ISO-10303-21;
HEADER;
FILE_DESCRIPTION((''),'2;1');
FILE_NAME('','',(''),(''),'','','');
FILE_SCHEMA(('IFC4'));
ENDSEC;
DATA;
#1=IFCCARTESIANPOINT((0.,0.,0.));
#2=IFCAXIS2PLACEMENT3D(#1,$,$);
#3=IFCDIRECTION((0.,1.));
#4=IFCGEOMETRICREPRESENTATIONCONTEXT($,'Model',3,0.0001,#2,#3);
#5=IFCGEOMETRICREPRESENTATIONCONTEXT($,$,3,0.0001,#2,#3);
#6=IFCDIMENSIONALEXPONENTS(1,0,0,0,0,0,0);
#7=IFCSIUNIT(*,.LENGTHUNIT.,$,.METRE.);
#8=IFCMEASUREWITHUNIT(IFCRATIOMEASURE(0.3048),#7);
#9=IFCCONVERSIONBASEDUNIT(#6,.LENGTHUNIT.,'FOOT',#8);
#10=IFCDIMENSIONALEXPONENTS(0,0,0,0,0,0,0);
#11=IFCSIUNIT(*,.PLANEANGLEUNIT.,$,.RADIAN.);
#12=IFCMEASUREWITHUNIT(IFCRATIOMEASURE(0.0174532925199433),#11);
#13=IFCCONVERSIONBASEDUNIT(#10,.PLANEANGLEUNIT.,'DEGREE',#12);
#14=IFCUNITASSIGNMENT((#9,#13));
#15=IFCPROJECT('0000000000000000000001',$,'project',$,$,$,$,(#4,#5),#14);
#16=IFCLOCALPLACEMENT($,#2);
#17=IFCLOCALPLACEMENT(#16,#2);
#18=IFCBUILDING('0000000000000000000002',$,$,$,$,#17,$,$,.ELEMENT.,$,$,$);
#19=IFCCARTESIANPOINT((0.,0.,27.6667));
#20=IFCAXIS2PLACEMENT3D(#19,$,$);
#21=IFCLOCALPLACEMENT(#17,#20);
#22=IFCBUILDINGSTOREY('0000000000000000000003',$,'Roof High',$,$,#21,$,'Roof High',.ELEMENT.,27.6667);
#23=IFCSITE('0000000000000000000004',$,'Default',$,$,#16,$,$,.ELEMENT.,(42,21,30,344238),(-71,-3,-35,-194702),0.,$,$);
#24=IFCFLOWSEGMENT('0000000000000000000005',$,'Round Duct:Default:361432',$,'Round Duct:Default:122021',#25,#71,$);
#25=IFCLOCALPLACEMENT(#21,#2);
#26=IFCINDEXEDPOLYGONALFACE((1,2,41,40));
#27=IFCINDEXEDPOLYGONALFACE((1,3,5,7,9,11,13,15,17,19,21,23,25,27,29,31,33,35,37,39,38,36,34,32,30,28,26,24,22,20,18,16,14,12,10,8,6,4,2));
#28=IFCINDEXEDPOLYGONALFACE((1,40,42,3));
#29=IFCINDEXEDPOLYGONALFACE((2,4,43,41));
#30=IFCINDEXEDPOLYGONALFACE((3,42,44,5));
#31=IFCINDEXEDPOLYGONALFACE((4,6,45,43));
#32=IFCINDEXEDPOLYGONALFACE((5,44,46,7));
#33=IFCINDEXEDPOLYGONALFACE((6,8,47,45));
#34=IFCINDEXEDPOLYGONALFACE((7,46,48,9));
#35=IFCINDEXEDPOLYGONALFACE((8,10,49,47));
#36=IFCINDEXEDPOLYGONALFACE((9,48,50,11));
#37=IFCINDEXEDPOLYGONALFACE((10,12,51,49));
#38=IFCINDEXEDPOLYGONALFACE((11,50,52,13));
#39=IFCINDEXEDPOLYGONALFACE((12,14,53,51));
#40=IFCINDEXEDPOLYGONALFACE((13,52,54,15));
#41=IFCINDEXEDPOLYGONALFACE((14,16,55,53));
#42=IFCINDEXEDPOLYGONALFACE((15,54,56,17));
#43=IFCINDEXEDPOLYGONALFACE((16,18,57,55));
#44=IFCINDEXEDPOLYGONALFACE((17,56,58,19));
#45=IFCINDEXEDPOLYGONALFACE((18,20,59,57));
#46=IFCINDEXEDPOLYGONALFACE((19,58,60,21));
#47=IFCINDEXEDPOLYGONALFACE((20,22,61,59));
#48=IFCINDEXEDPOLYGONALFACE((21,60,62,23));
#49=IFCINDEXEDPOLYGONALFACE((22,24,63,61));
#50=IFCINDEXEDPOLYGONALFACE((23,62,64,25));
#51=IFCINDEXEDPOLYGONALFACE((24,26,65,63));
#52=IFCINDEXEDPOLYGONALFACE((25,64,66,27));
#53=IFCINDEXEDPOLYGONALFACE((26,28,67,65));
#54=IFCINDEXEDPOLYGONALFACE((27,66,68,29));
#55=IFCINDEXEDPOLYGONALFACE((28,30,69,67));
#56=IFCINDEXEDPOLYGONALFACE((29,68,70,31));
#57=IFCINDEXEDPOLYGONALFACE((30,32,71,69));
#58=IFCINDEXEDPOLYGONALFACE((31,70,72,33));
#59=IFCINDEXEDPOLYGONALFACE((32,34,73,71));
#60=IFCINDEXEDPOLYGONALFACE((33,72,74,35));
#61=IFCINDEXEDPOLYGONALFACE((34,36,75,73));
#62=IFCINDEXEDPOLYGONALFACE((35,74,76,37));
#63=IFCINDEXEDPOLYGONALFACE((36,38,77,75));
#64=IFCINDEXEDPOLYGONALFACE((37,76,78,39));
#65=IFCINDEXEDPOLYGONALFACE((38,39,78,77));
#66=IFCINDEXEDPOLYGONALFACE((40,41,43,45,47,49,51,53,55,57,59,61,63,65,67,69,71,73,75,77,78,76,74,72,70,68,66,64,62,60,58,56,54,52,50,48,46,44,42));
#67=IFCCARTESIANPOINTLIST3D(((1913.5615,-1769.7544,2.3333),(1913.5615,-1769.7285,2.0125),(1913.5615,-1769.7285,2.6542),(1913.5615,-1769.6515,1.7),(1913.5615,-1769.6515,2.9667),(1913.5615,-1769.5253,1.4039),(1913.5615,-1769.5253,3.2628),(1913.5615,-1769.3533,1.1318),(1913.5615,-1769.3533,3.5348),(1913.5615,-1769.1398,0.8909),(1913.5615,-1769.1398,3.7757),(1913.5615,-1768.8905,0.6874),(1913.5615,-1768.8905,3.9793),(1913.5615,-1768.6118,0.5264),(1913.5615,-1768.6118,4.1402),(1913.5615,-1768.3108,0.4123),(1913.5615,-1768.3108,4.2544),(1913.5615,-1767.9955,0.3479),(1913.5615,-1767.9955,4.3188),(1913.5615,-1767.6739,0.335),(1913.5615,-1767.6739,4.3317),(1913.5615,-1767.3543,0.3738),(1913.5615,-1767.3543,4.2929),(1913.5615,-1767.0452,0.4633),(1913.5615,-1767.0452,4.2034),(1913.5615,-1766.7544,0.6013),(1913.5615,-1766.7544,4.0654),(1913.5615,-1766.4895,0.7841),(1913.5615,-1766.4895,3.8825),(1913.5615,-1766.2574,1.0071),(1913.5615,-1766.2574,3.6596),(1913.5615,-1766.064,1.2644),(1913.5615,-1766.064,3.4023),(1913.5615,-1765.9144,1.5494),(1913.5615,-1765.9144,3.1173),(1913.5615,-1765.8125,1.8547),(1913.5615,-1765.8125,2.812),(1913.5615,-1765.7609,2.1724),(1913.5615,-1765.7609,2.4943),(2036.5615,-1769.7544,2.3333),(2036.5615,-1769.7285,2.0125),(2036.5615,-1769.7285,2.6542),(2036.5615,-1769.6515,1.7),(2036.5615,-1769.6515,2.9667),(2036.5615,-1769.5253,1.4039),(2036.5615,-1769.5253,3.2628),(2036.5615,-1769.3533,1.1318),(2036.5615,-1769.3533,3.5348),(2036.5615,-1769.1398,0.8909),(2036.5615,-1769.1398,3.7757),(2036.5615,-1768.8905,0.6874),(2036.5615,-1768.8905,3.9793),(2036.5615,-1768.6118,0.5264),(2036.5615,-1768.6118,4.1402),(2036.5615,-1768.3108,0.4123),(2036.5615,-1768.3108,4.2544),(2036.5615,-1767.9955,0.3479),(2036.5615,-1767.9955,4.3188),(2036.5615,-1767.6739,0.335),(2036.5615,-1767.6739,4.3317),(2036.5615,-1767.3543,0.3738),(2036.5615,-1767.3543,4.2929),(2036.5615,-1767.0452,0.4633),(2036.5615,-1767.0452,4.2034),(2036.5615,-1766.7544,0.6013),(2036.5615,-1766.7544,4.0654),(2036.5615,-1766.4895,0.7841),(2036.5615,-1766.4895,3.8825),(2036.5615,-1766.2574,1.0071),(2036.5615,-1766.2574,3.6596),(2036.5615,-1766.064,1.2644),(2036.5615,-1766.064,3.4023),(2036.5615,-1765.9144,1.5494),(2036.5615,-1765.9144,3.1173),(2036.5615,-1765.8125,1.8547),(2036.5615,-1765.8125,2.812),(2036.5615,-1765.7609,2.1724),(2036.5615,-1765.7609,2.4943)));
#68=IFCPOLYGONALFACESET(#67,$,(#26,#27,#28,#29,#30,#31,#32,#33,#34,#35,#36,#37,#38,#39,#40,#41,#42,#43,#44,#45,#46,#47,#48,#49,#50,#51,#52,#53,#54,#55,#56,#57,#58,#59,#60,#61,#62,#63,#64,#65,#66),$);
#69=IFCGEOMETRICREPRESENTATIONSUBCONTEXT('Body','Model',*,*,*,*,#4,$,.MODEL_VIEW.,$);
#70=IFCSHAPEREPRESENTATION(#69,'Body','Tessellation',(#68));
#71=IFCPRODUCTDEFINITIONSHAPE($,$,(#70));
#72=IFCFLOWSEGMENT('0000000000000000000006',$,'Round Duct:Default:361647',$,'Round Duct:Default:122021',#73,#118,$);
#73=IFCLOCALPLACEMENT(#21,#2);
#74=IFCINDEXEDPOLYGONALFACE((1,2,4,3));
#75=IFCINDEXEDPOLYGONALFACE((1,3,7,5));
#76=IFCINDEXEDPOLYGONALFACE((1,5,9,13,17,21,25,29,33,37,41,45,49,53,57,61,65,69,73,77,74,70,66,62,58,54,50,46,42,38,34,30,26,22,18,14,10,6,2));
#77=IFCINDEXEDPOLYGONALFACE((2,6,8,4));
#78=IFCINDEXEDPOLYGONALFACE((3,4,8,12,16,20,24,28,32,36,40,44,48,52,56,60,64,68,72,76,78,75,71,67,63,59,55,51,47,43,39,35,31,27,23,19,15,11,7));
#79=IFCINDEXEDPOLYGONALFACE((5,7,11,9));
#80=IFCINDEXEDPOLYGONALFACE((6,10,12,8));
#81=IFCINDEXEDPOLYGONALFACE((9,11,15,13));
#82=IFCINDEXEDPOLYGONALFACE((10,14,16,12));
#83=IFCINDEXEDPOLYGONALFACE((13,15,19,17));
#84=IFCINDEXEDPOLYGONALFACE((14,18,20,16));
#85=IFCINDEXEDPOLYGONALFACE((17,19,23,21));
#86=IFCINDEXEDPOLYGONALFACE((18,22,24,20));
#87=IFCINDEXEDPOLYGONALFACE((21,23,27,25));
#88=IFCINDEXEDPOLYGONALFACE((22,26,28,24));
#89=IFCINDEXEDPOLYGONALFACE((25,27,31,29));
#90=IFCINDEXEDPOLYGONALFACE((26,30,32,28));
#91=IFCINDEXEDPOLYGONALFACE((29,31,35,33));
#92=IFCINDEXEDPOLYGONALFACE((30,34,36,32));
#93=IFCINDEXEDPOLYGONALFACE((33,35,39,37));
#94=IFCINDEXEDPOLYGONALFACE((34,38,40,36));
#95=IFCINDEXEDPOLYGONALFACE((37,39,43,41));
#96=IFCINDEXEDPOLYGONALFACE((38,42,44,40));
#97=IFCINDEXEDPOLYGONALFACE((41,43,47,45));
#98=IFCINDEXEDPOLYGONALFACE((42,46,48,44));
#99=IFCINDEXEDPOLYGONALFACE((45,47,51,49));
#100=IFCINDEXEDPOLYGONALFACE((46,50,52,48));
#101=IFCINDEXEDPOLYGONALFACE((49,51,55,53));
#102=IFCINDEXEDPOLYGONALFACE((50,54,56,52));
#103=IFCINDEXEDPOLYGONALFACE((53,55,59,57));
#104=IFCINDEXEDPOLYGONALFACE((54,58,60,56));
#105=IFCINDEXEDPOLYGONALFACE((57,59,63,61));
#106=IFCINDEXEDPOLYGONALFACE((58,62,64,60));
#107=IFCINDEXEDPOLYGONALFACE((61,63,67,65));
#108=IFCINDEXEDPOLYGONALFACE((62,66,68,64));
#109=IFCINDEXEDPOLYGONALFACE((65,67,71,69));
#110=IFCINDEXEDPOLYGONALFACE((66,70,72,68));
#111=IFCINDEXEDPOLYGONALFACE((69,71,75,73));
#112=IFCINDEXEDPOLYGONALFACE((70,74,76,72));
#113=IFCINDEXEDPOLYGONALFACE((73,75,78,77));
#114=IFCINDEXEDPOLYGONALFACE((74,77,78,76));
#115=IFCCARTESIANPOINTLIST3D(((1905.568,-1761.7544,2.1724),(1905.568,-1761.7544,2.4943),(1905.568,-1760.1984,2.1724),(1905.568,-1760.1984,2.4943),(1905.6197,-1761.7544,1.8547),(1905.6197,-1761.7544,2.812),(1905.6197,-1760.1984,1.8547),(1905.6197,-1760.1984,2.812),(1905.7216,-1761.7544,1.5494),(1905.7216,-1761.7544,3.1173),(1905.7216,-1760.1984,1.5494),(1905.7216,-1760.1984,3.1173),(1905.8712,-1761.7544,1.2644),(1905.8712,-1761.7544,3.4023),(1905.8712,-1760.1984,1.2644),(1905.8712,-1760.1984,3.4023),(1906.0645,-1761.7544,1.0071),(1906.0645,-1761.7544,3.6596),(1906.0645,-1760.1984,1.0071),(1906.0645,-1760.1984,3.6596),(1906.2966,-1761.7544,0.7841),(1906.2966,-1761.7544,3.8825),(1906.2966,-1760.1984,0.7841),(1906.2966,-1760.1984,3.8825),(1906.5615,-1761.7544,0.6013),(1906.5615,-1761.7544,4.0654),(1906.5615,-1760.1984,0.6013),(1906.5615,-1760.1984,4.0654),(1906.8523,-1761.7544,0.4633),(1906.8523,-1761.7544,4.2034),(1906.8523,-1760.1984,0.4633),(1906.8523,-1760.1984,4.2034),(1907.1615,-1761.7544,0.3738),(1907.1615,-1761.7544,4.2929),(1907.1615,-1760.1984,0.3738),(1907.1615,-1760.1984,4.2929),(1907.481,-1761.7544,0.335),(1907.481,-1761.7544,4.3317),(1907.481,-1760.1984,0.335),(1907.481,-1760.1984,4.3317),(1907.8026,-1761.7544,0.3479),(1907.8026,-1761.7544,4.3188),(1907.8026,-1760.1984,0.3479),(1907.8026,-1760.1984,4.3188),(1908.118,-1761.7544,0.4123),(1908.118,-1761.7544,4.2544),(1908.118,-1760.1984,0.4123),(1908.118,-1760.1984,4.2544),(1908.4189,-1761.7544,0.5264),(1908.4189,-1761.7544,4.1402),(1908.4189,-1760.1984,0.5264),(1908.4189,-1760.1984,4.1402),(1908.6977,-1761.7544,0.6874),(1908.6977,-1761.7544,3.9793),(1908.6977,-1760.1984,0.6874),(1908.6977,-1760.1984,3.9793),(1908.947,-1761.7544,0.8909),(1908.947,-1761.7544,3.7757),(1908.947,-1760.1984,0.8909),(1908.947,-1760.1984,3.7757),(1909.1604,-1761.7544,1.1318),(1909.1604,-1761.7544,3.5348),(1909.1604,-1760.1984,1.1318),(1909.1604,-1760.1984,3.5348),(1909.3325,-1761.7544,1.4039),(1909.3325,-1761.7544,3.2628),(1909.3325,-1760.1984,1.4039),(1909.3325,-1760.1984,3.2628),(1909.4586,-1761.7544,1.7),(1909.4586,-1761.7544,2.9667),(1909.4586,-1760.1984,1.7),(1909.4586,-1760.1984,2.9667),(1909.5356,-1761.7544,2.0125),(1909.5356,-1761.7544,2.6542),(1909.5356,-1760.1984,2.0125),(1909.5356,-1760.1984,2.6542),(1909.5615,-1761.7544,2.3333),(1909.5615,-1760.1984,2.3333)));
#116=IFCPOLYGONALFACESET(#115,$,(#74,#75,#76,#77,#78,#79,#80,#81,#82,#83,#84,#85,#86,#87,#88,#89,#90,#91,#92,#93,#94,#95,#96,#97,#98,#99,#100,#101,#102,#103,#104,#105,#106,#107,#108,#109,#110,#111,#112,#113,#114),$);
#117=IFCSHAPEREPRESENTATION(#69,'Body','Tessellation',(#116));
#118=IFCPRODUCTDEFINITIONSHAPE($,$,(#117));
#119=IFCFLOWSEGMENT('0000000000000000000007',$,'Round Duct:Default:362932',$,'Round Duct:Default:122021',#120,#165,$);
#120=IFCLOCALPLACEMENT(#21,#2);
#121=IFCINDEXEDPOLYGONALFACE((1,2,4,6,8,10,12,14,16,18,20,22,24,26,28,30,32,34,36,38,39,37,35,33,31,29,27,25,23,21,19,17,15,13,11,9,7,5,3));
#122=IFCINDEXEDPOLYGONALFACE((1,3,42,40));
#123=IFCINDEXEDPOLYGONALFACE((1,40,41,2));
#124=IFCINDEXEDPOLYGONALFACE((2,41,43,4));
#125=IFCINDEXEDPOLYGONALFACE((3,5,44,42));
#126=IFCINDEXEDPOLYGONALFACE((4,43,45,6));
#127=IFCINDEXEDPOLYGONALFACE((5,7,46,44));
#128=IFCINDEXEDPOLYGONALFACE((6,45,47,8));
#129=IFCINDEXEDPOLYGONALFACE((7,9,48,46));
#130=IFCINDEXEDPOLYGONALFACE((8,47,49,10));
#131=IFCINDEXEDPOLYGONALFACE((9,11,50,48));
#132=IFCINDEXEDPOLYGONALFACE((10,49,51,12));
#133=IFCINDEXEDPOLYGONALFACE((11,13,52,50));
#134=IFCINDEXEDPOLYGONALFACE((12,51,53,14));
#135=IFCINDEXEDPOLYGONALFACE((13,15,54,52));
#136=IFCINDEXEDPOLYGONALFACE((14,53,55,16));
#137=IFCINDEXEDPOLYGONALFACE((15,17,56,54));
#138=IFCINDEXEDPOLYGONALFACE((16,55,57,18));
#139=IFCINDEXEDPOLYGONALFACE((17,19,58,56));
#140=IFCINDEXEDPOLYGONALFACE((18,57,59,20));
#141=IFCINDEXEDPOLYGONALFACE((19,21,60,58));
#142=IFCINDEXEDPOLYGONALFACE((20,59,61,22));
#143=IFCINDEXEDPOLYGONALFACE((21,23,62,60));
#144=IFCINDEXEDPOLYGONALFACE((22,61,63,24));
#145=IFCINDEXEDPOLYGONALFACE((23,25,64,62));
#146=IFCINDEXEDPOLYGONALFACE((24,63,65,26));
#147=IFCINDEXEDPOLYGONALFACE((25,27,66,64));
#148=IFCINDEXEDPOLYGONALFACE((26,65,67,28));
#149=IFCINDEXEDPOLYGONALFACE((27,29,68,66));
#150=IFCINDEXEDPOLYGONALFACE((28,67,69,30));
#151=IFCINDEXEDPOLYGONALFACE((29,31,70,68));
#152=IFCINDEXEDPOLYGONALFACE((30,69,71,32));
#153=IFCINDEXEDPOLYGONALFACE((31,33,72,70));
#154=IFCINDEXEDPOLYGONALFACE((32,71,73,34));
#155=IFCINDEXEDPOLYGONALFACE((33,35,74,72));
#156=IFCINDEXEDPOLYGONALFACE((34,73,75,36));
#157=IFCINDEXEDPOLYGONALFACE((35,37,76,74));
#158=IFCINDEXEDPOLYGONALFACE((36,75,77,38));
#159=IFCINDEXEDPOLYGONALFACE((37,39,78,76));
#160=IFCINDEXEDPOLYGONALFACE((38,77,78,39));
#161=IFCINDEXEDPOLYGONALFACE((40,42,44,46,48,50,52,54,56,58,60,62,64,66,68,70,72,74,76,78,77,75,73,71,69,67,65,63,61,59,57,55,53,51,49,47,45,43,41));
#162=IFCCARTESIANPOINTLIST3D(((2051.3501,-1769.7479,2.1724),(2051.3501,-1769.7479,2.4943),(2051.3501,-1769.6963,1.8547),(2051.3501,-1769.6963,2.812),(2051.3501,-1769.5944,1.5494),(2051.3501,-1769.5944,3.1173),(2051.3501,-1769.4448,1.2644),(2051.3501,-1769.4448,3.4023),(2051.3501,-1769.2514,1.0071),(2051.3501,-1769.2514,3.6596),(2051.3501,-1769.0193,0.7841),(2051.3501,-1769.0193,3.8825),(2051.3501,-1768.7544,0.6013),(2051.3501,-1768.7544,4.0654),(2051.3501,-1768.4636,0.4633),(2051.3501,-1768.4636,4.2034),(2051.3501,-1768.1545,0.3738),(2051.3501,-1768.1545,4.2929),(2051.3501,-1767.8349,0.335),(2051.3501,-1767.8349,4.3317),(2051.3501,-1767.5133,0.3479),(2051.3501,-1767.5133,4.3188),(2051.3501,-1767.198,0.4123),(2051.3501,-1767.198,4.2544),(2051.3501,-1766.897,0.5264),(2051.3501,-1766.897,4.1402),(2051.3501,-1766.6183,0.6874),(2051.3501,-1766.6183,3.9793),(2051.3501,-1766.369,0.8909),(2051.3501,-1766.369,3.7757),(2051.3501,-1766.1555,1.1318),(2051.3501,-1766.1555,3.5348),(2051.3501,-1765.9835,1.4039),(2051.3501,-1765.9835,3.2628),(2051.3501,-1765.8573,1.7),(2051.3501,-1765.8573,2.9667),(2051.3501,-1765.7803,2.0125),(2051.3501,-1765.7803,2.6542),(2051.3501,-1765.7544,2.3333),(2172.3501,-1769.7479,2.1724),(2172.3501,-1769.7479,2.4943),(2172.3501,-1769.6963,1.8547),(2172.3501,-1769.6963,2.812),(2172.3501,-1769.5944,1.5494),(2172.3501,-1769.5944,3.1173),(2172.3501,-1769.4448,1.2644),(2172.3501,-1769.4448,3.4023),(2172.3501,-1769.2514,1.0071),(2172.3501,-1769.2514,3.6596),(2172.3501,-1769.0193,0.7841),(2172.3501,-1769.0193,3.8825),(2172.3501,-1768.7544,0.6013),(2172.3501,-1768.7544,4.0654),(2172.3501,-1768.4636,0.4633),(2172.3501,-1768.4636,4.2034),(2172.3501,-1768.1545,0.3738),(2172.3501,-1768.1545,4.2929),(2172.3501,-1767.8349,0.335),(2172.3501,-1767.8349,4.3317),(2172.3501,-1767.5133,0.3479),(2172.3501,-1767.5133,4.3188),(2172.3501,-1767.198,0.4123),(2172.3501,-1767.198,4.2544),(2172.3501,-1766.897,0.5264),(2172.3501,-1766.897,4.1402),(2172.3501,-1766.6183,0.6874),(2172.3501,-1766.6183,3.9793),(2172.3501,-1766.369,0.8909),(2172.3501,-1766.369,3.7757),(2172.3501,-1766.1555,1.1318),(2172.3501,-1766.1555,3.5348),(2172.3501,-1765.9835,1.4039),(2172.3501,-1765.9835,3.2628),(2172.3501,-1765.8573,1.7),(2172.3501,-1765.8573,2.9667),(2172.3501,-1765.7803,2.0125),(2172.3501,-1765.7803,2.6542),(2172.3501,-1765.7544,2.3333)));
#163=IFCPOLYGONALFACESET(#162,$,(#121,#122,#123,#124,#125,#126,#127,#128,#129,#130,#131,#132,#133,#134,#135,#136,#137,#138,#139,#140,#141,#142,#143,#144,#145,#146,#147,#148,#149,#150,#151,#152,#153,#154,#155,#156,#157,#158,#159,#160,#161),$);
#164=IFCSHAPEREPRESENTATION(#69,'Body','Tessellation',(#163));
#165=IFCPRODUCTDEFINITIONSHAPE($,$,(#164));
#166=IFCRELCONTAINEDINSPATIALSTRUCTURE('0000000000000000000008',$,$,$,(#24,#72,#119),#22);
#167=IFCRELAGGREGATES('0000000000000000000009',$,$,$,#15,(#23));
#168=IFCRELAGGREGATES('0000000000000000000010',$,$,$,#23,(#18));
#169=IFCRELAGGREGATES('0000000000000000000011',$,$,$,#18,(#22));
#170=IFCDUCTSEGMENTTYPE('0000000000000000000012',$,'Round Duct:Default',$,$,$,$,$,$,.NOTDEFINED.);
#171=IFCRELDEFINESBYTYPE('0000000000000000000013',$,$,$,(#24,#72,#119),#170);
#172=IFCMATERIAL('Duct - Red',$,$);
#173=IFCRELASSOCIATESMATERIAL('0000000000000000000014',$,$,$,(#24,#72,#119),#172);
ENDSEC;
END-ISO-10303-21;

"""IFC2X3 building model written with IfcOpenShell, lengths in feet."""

from ifc_helpers import new_model, entity, si_unit, converted_unit, direction, frame, origin, origin_2d_with_axis, place, context, subcontext, project, spatial, circle, extrude, material, type_object, element, save


model = new_model("IFC2X3")

# Units and contexts
model_context = context("Model", 3, precision=0.0001, world=origin(), true_north=direction((0.0, 1.0)))
context_of_model = context(None, 3, precision=0.0001, world=origin(), true_north=direction((0.0, 1.0)))
body_context = subcontext(model_context, "Body", "Model", "MODEL_VIEW")
ifc_project = project(units=[converted_unit("LENGTHUNIT", "FOOT", entity("IfcRatioMeasure", 0.3048), si_unit("LENGTHUNIT", "METRE"), dimensions=[1, 0, 0, 0, 0, 0, 0]), converted_unit("PLANEANGLEUNIT", "DEGREE", entity("IfcRatioMeasure", 0.0174532925199433), si_unit("PLANEANGLEUNIT", "RADIAN"), dimensions=[0, 0, 0, 0, 0, 0, 0])], contexts=[model_context, context_of_model])

# Site, building, storey
site_placement = place(None, origin())
site = spatial("IfcSite", under=ifc_project, at=site_placement, Name="Default", CompositionType="ELEMENT", RefLatitude=(42, 21, 30, 344238), RefLongitude=(-71, -3, -35, -194702), RefElevation=0.0)
building_placement = place(site_placement, origin())
building = spatial("IfcBuilding", under=site, at=building_placement, CompositionType="ELEMENT")
storey_placement = place(building_placement, frame((0.0, 0.0, 27.6667)))
storey = spatial("IfcBuildingStorey", under=building, at=storey_placement, Name="Roof High", LongName="Roof High", CompositionType="ELEMENT", Elevation=27.6667)

# Flow segments
ifc_material = material(Name="Duct - Red")
duct_segment_type = type_object("IfcDuctSegmentType", Name="Round Duct:Default", PredefinedType="NOTDEFINED")
flow_segment_1_placement = place(storey_placement, origin())
element("IfcFlowSegment", 1, at=flow_segment_1_placement, inside=storey, type_object=duct_segment_type, material=ifc_material, Name="Round Duct:Default:361432", ObjectType="Round Duct:Default:122021", context=body_context, shape_type="SweptSolid", body=[
    extrude(circle(Radius=2.0, at=origin_2d_with_axis()), frame((1913.5615, -1767.7544, 2.3333), z_axis=(1.0, 0.0, 0.0), x_axis=(0.0, -1.0, 0.0)), (0.0, 0.0, 1.0), 123.0),
])
flow_segment_2_placement = place(storey_placement, origin())
element("IfcFlowSegment", 2, at=flow_segment_2_placement, inside=storey, type_object=duct_segment_type, material=ifc_material, Name="Round Duct:Default:361647", ObjectType="Round Duct:Default:122021", context=body_context, shape_type="SweptSolid", body=[
    extrude(circle(Radius=2.0, at=origin_2d_with_axis()), frame((1907.5615, -1761.7544, 2.3333), z_axis=(0.0, 1.0, 0.0), x_axis=(1.0, 0.0, 0.0)), (0.0, 0.0, 1.0), 1.556),
])
flow_segment_3_placement = place(storey_placement, origin())
element("IfcFlowSegment", 3, at=flow_segment_3_placement, inside=storey, type_object=duct_segment_type, material=ifc_material, Name="Round Duct:Default:362932", ObjectType="Round Duct:Default:122021", context=body_context, shape_type="SweptSolid", body=[
    extrude(circle(Radius=2.0, at=origin_2d_with_axis()), frame((2051.3501, -1767.7544, 2.3333), z_axis=(1.0, 0.0, 0.0), x_axis=(0.0, 1.0, 0.0)), (0.0, 0.0, 1.0), 121.0),
])

save(model, "model.ifc")
